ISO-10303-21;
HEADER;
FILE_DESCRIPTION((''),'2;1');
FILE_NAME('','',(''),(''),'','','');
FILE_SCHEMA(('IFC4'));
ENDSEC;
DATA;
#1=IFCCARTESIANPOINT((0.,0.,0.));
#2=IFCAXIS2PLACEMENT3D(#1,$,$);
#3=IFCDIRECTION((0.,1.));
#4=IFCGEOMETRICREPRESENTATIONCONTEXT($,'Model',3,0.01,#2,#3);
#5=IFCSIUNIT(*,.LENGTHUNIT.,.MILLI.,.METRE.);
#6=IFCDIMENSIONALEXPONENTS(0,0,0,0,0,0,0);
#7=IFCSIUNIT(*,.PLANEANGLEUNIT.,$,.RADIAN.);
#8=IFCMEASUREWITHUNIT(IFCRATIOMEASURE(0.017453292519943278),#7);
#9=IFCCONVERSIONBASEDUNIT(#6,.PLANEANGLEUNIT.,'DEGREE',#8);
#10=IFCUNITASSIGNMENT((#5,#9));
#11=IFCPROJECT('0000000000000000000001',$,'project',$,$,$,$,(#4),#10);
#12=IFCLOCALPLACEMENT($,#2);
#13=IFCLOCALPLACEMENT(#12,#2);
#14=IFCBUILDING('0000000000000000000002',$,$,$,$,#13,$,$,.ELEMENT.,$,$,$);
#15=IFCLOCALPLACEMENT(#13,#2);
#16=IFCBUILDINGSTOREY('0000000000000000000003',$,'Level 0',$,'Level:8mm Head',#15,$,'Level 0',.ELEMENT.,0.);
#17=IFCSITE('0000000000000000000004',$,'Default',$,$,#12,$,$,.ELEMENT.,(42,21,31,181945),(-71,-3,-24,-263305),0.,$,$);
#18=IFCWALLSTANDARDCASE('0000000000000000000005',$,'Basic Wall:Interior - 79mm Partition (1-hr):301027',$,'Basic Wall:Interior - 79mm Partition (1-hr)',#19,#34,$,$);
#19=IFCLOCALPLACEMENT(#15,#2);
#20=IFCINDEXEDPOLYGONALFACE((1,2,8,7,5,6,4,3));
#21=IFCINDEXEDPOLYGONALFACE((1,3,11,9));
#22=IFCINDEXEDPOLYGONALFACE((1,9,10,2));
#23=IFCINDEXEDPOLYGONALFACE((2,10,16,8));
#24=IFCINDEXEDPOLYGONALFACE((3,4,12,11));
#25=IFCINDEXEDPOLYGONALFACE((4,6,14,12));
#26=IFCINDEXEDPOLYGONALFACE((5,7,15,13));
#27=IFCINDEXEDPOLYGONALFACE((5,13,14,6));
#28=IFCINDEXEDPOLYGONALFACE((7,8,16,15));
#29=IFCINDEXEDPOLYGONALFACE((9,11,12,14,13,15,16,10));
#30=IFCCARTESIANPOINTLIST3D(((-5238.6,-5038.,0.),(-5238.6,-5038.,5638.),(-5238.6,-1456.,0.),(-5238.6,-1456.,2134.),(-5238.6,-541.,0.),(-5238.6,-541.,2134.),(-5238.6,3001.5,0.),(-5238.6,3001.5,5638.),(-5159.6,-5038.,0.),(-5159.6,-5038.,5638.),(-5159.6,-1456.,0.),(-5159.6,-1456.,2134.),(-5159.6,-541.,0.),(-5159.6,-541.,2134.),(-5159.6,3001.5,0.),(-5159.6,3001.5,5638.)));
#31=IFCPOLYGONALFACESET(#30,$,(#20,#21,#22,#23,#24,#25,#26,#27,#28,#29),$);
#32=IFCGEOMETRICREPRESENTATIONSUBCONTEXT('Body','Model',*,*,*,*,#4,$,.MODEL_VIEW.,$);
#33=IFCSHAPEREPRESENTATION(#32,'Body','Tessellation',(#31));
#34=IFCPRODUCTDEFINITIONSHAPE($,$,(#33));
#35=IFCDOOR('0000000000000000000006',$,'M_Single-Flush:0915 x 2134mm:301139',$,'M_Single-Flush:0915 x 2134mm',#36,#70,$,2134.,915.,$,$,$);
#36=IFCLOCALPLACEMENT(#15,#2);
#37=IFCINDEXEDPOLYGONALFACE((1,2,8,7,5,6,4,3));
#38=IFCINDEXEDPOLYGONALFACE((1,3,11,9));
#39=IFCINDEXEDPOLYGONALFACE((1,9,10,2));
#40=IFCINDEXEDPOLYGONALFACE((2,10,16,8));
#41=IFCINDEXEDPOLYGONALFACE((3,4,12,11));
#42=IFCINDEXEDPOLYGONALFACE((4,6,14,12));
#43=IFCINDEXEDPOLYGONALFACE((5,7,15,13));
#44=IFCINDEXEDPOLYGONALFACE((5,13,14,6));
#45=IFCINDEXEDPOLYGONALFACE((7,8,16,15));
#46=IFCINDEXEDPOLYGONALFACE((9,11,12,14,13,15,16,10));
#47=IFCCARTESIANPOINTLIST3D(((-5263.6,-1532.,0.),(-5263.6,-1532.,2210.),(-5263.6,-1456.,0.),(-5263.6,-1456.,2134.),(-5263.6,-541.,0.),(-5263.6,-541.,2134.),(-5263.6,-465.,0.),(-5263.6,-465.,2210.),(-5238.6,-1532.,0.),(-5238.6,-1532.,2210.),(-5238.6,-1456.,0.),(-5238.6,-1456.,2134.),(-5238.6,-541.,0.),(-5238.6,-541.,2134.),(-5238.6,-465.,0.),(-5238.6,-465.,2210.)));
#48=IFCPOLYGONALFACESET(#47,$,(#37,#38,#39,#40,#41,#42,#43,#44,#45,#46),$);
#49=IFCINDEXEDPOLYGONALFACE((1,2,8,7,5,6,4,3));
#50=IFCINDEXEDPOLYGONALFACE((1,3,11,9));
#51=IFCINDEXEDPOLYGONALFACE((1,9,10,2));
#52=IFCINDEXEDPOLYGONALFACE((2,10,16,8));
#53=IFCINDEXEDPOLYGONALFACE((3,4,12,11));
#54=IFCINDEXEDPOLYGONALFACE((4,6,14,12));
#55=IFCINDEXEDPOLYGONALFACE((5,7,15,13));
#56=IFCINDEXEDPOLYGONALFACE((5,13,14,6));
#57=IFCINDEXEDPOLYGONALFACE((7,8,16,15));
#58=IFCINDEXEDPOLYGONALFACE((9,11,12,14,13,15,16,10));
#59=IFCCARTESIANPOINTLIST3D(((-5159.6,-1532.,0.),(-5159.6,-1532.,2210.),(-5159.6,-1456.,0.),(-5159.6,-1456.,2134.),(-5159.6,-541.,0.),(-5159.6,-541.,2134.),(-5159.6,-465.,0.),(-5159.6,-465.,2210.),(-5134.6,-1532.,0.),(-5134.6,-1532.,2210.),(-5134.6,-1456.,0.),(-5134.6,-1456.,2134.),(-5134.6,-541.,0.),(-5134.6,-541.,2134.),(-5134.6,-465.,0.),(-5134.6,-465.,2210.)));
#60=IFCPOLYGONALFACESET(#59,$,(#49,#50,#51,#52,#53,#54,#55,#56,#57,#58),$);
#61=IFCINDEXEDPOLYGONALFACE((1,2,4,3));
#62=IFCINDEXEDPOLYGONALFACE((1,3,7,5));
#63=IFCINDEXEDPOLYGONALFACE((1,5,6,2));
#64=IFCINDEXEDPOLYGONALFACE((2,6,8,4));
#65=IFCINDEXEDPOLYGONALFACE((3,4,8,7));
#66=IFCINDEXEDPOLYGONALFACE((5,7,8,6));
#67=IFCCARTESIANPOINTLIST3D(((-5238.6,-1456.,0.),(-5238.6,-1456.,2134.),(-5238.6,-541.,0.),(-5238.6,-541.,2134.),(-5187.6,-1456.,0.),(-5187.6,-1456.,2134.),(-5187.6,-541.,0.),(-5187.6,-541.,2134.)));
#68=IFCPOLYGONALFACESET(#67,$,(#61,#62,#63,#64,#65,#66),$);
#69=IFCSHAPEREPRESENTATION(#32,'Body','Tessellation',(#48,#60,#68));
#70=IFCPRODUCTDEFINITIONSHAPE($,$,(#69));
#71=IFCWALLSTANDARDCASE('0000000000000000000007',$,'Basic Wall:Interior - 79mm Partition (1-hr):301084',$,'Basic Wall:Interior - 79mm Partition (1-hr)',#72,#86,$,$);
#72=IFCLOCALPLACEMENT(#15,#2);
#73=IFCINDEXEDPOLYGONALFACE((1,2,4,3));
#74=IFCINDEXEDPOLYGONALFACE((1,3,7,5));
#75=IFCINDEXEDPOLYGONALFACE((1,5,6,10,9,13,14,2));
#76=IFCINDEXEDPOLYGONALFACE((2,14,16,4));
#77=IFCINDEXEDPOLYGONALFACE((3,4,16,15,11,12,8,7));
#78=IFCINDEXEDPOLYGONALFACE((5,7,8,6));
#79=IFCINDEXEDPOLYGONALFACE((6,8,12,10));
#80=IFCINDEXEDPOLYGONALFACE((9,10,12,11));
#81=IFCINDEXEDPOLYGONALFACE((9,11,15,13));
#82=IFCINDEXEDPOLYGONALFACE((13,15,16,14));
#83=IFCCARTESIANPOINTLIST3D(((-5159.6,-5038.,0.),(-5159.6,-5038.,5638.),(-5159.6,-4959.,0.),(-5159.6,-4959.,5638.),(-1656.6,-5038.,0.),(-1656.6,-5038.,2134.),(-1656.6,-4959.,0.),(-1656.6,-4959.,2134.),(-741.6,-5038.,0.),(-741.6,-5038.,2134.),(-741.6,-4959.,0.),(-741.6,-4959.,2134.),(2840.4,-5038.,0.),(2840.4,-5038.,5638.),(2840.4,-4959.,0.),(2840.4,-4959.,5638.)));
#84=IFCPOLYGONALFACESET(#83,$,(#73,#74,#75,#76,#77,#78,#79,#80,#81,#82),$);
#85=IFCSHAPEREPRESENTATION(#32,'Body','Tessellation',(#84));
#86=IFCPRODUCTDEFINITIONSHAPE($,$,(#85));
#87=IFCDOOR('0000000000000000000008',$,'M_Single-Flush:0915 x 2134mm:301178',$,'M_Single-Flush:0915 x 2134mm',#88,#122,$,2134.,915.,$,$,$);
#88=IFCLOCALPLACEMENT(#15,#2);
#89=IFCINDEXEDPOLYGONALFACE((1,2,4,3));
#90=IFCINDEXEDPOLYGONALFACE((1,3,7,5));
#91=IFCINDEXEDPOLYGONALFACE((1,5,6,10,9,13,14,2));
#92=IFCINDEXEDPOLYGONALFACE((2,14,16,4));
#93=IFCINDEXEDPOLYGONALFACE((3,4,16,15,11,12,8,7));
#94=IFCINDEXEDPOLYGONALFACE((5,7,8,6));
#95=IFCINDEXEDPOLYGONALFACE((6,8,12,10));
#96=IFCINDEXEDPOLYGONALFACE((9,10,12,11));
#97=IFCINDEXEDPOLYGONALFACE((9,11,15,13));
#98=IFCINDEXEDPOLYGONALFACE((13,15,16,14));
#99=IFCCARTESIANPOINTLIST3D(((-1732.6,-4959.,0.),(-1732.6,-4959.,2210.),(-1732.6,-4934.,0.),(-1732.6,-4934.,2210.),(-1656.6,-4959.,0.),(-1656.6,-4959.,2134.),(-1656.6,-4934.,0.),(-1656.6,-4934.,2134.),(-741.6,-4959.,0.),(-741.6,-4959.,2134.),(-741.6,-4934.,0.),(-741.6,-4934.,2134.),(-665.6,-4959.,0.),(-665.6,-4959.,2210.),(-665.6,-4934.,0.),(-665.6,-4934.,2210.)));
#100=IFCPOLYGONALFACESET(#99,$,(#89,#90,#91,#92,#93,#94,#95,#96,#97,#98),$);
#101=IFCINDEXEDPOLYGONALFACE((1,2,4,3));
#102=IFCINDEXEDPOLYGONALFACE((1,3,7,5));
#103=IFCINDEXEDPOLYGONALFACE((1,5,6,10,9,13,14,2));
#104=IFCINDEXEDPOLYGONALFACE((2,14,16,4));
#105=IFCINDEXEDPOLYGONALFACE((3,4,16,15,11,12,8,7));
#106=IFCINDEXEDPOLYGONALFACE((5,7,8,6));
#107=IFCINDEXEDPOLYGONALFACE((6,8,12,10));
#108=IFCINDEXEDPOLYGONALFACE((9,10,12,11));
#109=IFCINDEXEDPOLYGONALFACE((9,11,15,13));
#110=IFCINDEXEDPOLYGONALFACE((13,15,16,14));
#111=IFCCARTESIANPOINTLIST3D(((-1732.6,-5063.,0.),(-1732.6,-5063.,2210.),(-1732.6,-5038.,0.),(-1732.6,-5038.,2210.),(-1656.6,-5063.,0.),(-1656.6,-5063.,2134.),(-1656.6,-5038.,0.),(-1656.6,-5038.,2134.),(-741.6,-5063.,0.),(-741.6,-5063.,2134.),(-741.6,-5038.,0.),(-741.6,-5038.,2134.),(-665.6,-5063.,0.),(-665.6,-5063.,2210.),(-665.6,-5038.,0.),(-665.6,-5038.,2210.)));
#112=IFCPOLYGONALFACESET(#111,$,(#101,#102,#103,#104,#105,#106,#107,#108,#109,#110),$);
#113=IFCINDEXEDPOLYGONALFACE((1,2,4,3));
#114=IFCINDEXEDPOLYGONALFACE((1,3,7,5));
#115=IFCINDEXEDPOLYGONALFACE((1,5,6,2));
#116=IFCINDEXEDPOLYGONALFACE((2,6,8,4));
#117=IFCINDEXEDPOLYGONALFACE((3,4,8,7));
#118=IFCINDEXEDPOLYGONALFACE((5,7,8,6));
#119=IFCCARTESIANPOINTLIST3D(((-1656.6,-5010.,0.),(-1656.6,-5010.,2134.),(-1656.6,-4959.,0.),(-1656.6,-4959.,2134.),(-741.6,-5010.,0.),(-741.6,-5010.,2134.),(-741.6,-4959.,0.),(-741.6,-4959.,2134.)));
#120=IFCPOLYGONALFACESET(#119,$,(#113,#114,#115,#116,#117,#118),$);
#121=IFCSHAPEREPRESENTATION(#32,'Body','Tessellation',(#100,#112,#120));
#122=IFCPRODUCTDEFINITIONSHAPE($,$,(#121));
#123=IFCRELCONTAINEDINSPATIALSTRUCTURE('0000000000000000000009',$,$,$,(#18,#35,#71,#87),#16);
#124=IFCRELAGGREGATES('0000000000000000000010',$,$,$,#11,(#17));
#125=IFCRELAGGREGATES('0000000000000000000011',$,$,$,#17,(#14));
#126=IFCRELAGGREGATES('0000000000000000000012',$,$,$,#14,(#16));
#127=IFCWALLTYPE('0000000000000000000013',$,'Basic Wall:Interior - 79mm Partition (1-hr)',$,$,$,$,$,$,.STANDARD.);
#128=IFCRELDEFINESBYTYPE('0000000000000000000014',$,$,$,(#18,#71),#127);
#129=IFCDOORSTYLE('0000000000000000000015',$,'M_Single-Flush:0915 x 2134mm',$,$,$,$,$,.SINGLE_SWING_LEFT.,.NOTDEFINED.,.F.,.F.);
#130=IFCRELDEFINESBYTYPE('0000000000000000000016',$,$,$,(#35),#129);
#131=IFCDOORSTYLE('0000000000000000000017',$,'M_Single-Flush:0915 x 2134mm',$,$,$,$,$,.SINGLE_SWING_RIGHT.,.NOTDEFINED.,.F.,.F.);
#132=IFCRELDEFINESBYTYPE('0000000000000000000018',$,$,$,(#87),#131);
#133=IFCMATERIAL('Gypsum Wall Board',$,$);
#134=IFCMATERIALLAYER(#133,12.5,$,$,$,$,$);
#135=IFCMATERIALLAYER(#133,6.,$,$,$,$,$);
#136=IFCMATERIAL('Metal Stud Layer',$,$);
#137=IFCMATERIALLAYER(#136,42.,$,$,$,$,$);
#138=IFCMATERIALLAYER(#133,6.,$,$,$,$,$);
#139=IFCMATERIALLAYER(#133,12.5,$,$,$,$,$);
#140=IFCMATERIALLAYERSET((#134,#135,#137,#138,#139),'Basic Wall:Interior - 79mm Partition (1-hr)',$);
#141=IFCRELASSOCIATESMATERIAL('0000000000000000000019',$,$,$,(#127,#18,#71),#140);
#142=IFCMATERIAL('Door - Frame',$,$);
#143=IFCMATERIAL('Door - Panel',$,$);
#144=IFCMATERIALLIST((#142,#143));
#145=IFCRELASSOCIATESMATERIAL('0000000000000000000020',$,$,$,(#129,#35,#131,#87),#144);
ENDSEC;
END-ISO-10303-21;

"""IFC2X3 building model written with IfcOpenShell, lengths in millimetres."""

from ifc_helpers import new_model, entity, si_unit, converted_unit, direction, frame, frame_2d, origin, origin_2d_with_axis, place, context, subcontext, project, spatial, polyline, rectangle, outline, extrude, clip, bounded_halfspace, source, transform, mapped, material, material_list, layer, layer_set, layer_usage, type_object, type_shapes, element, fill, save


model = new_model("IFC2X3")

# Units and contexts
model_context = context("Model", 3, precision=0.01, world=origin(), true_north=direction((0.0, 1.0)))
body_context = subcontext(model_context, "Body", "Model", "MODEL_VIEW")
ifc_project = project(units=[si_unit("LENGTHUNIT", "METRE", prefix="MILLI"), converted_unit("PLANEANGLEUNIT", "DEGREE", entity("IfcRatioMeasure", 0.017453292519943278), si_unit("PLANEANGLEUNIT", "RADIAN"), dimensions=[0, 0, 0, 0, 0, 0, 0])], contexts=[model_context])

# Site, building, storey
site_placement = place(None, origin())
site = spatial("IfcSite", under=ifc_project, at=site_placement, Name="Default", CompositionType="ELEMENT", RefLatitude=(42, 21, 31, 181945), RefLongitude=(-71, -3, -24, -263305), RefElevation=0.0)
building_placement = place(site_placement, origin())
building = spatial("IfcBuilding", under=site, at=building_placement, CompositionType="ELEMENT")
storey_placement = place(building_placement, origin())
storey = spatial("IfcBuildingStorey", under=building, at=storey_placement, Name="Level 0", ObjectType="Level:8mm Head", LongName="Level 0", CompositionType="ELEMENT", Elevation=0.0)

# Shared definitions
ifc_material_1 = material(Name="Metal Stud Layer")
ifc_material_2 = material(Name="Gypsum Wall Board")
ifc_material_3 = material(Name="Door - Frame")
ifc_material_4 = material(Name="Door - Panel")
ifc_material_list_1 = material_list([ifc_material_3, ifc_material_4])

# Walls, openings, doors
ifc_layer_1 = layer(ifc_material_2, 12.5)
ifc_layer_2 = layer(ifc_material_2, 6.0)
ifc_layer_3 = layer(ifc_material_1, 42.0)
ifc_layer_4 = layer(ifc_material_2, 6.0)
ifc_layer_5 = layer(ifc_material_2, 12.5)
ifc_layer_set_1 = layer_set([ifc_layer_1, ifc_layer_2, ifc_layer_3, ifc_layer_4, ifc_layer_5], Name="Basic Wall:Interior - 79mm Partition (1-hr)")
ifc_layer_usage_1 = layer_usage(ifc_layer_set_1, "AXIS2", "NEGATIVE", 39.5)
wall_type_1 = type_object("IfcWallType", Name="Basic Wall:Interior - 79mm Partition (1-hr)", PredefinedType="STANDARD", material=ifc_layer_set_1)
wall_1_placement = place(storey_placement, frame((-5199.1, 3001.5, 0.0), z_axis=(0.0, 0.0, 1.0), x_axis=(0.0, -1.0, 0.0)))
wall_1 = element("IfcWallStandardCase", 1, at=wall_1_placement, inside=storey, type_object=wall_type_1, material=ifc_layer_usage_1, Name="Basic Wall:Interior - 79mm Partition (1-hr):301027", ObjectType="Basic Wall:Interior - 79mm Partition (1-hr)", context=body_context, shape_type="Clipping", body=[
    clip(extrude(rectangle(XDim=8039.5, YDim=79.0, at=frame_2d((4019.8, 0.0), x_axis=(1.0, 0.0))), origin(), (0.0, 0.0, 1.0), 5638.0), bounded_halfspace(frame((0.0, -39.5, 5638.0), z_axis=(0.0, 0.0, -1.0), x_axis=(1.0, 0.0, 0.0)), True, frame((0.0, -39.5, 5638.0)), polyline([(0.0, 0.0), (2450439.6, 0.0), (2450439.6, 24079.2), (2426360.4, 24079.2), (0.0, 24079.2), (0.0, 0.0)]))),
])
opening_1_placement = place(wall_1_placement, frame((4457.5, 39.5, 0.0)))
opening_1 = element("IfcOpeningElement", 2, at=opening_1_placement, cuts=wall_1, ObjectType="Opening", context=body_context, shape_type="SweptSolid", body=[
    extrude(rectangle(XDim=915.0, YDim=2134.0, at=frame_2d((1067.0, 457.5), x_axis=(0.0, -1.0))), frame((0.0, 0.0, 0.0), z_axis=(0.0, -1.0, 0.0), x_axis=(0.0, 0.0, 1.0)), (0.0, 0.0, 1.0), 79.0),
])
door_style_1 = type_object("IfcDoorStyle", Name="M_Single-Flush:0915 x 2134mm", ConstructionType="NOTDEFINED", OperationType="SINGLE_SWING_LEFT", ParameterTakesPrecedence=False, Sizeable=False, material=ifc_material_list_1)
shared_shape_1 = source(origin(), body_context, "Body", "SweptSolid", [
    extrude(outline(polyline([(-533.5, -1124.0), (533.5, -1124.0), (533.5, 1086.0), (457.5, 1086.0), (457.5, -1048.0), (-457.5, -1048.0), (-457.5, 1086.0), (-533.5, 1086.0), (-533.5, -1124.0)])), frame((457.5, 104.0, 1086.0), z_axis=(0.0, -1.0, 0.0), x_axis=(-1.0, 0.0, 0.0)), (0.0, 0.0, 1.0), 25.0),
    extrude(outline(polyline([(-1124.0, -533.5), (1086.0, -533.5), (1086.0, -457.5), (-1048.0, -457.5), (-1048.0, 457.5), (1086.0, 457.5), (1086.0, 533.5), (-1124.0, 533.5), (-1124.0, -533.5)])), frame((457.5, 0.0, 1086.0), z_axis=(0.0, -1.0, 0.0), x_axis=(0.0, 0.0, -1.0)), (0.0, 0.0, 1.0), 25.0),
    extrude(rectangle(XDim=915.0, YDim=51.0, at=origin_2d_with_axis()), frame((457.5, 53.5, 0.0)), (0.0, 0.0, 1.0), 2134.0),
])
type_shapes(door_style_1, [shared_shape_1])
door_1_placement = place(opening_1_placement, frame((0.0, 0.0, 0.0), z_axis=(0.0, 0.0, 1.0), x_axis=(-1.0, 0.0, 0.0)))
door_1 = element("IfcDoor", 3, at=door_1_placement, inside=storey, type_object=door_style_1, material=ifc_material_list_1, Name="M_Single-Flush:0915 x 2134mm:301139", ObjectType="M_Single-Flush:0915 x 2134mm", OverallHeight=2134.0, OverallWidth=915.0, context=body_context, shape_type="MappedRepresentation", body=[
    mapped(shared_shape_1, transform((0.0, 0.0, 0.0), scale=1.0)),
])
fill(opening_1, door_1)
wall_2_placement = place(storey_placement, frame((-5159.6, -4998.5, 0.0)))
wall_2 = element("IfcWallStandardCase", 4, at=wall_2_placement, inside=storey, type_object=wall_type_1, material=ifc_layer_usage_1, Name="Basic Wall:Interior - 79mm Partition (1-hr):301084", ObjectType="Basic Wall:Interior - 79mm Partition (1-hr)", context=body_context, shape_type="Clipping", body=[
    clip(extrude(rectangle(XDim=8000.0, YDim=79.0, at=frame_2d((4000.0, 0.0), x_axis=(1.0, 0.0))), origin(), (0.0, 0.0, 1.0), 5638.0), bounded_halfspace(frame((0.0, -39.5, 5638.0), z_axis=(0.0, 0.0, -1.0), x_axis=(0.0, -1.0, 0.0)), True, frame((0.0, -39.5, 5638.0)), polyline([(0.0, 0.0), (2414320.8, 0.0), (2438400.0, 0.0), (2438400.0, 24079.2), (0.0, 24079.2), (0.0, 0.0)]))),
])
opening_2_placement = place(wall_2_placement, frame((3503.0, -39.5, 0.0)))
opening_2 = element("IfcOpeningElement", 5, at=opening_2_placement, cuts=wall_2, ObjectType="Opening", context=body_context, shape_type="SweptSolid", body=[
    extrude(rectangle(XDim=915.0, YDim=2134.0, at=frame_2d((1067.0, 457.5), x_axis=(0.0, 1.0))), frame((0.0, 0.0, 0.0), z_axis=(0.0, 1.0, 0.0), x_axis=(0.0, 0.0, 1.0)), (0.0, 0.0, 1.0), 79.0),
])
door_style_2 = type_object("IfcDoorStyle", Name="M_Single-Flush:0915 x 2134mm", ConstructionType="NOTDEFINED", OperationType="SINGLE_SWING_RIGHT", ParameterTakesPrecedence=False, Sizeable=False, material=ifc_material_list_1)
shared_shape_2 = source(origin(), body_context, "Body", "SweptSolid", [
    extrude(outline(polyline([(-533.5, -1124.0), (533.5, -1124.0), (533.5, 1086.0), (457.5, 1086.0), (457.5, -1048.0), (-457.5, -1048.0), (-457.5, 1086.0), (-533.5, 1086.0), (-533.5, -1124.0)])), frame((457.5, 79.0, 1086.0), z_axis=(0.0, 1.0, 0.0), x_axis=(1.0, 0.0, 0.0)), (0.0, 0.0, 1.0), 25.0),
    extrude(outline(polyline([(-1124.0, -533.5), (1086.0, -533.5), (1086.0, -457.5), (-1048.0, -457.5), (-1048.0, 457.5), (1086.0, 457.5), (1086.0, 533.5), (-1124.0, 533.5), (-1124.0, -533.5)])), frame((457.5, -25.0, 1086.0), z_axis=(0.0, 1.0, 0.0), x_axis=(0.0, 0.0, -1.0)), (0.0, 0.0, 1.0), 25.0),
    extrude(rectangle(XDim=51.0, YDim=915.0, at=origin_2d_with_axis()), frame((457.5, 53.5, 0.0), z_axis=(0.0, 0.0, 1.0), x_axis=(0.0, 1.0, 0.0)), (0.0, 0.0, 1.0), 2134.0),
])
type_shapes(door_style_2, [shared_shape_2])
door_2_placement = place(opening_2_placement, origin())
door_2 = element("IfcDoor", 6, at=door_2_placement, inside=storey, type_object=door_style_2, material=ifc_material_list_1, Name="M_Single-Flush:0915 x 2134mm:301178", ObjectType="M_Single-Flush:0915 x 2134mm", OverallHeight=2134.0, OverallWidth=915.0, context=body_context, shape_type="MappedRepresentation", body=[
    mapped(shared_shape_2, transform((0.0, 0.0, 0.0), scale=1.0)),
])
fill(opening_2, door_2)

save(model, "model.ifc")
